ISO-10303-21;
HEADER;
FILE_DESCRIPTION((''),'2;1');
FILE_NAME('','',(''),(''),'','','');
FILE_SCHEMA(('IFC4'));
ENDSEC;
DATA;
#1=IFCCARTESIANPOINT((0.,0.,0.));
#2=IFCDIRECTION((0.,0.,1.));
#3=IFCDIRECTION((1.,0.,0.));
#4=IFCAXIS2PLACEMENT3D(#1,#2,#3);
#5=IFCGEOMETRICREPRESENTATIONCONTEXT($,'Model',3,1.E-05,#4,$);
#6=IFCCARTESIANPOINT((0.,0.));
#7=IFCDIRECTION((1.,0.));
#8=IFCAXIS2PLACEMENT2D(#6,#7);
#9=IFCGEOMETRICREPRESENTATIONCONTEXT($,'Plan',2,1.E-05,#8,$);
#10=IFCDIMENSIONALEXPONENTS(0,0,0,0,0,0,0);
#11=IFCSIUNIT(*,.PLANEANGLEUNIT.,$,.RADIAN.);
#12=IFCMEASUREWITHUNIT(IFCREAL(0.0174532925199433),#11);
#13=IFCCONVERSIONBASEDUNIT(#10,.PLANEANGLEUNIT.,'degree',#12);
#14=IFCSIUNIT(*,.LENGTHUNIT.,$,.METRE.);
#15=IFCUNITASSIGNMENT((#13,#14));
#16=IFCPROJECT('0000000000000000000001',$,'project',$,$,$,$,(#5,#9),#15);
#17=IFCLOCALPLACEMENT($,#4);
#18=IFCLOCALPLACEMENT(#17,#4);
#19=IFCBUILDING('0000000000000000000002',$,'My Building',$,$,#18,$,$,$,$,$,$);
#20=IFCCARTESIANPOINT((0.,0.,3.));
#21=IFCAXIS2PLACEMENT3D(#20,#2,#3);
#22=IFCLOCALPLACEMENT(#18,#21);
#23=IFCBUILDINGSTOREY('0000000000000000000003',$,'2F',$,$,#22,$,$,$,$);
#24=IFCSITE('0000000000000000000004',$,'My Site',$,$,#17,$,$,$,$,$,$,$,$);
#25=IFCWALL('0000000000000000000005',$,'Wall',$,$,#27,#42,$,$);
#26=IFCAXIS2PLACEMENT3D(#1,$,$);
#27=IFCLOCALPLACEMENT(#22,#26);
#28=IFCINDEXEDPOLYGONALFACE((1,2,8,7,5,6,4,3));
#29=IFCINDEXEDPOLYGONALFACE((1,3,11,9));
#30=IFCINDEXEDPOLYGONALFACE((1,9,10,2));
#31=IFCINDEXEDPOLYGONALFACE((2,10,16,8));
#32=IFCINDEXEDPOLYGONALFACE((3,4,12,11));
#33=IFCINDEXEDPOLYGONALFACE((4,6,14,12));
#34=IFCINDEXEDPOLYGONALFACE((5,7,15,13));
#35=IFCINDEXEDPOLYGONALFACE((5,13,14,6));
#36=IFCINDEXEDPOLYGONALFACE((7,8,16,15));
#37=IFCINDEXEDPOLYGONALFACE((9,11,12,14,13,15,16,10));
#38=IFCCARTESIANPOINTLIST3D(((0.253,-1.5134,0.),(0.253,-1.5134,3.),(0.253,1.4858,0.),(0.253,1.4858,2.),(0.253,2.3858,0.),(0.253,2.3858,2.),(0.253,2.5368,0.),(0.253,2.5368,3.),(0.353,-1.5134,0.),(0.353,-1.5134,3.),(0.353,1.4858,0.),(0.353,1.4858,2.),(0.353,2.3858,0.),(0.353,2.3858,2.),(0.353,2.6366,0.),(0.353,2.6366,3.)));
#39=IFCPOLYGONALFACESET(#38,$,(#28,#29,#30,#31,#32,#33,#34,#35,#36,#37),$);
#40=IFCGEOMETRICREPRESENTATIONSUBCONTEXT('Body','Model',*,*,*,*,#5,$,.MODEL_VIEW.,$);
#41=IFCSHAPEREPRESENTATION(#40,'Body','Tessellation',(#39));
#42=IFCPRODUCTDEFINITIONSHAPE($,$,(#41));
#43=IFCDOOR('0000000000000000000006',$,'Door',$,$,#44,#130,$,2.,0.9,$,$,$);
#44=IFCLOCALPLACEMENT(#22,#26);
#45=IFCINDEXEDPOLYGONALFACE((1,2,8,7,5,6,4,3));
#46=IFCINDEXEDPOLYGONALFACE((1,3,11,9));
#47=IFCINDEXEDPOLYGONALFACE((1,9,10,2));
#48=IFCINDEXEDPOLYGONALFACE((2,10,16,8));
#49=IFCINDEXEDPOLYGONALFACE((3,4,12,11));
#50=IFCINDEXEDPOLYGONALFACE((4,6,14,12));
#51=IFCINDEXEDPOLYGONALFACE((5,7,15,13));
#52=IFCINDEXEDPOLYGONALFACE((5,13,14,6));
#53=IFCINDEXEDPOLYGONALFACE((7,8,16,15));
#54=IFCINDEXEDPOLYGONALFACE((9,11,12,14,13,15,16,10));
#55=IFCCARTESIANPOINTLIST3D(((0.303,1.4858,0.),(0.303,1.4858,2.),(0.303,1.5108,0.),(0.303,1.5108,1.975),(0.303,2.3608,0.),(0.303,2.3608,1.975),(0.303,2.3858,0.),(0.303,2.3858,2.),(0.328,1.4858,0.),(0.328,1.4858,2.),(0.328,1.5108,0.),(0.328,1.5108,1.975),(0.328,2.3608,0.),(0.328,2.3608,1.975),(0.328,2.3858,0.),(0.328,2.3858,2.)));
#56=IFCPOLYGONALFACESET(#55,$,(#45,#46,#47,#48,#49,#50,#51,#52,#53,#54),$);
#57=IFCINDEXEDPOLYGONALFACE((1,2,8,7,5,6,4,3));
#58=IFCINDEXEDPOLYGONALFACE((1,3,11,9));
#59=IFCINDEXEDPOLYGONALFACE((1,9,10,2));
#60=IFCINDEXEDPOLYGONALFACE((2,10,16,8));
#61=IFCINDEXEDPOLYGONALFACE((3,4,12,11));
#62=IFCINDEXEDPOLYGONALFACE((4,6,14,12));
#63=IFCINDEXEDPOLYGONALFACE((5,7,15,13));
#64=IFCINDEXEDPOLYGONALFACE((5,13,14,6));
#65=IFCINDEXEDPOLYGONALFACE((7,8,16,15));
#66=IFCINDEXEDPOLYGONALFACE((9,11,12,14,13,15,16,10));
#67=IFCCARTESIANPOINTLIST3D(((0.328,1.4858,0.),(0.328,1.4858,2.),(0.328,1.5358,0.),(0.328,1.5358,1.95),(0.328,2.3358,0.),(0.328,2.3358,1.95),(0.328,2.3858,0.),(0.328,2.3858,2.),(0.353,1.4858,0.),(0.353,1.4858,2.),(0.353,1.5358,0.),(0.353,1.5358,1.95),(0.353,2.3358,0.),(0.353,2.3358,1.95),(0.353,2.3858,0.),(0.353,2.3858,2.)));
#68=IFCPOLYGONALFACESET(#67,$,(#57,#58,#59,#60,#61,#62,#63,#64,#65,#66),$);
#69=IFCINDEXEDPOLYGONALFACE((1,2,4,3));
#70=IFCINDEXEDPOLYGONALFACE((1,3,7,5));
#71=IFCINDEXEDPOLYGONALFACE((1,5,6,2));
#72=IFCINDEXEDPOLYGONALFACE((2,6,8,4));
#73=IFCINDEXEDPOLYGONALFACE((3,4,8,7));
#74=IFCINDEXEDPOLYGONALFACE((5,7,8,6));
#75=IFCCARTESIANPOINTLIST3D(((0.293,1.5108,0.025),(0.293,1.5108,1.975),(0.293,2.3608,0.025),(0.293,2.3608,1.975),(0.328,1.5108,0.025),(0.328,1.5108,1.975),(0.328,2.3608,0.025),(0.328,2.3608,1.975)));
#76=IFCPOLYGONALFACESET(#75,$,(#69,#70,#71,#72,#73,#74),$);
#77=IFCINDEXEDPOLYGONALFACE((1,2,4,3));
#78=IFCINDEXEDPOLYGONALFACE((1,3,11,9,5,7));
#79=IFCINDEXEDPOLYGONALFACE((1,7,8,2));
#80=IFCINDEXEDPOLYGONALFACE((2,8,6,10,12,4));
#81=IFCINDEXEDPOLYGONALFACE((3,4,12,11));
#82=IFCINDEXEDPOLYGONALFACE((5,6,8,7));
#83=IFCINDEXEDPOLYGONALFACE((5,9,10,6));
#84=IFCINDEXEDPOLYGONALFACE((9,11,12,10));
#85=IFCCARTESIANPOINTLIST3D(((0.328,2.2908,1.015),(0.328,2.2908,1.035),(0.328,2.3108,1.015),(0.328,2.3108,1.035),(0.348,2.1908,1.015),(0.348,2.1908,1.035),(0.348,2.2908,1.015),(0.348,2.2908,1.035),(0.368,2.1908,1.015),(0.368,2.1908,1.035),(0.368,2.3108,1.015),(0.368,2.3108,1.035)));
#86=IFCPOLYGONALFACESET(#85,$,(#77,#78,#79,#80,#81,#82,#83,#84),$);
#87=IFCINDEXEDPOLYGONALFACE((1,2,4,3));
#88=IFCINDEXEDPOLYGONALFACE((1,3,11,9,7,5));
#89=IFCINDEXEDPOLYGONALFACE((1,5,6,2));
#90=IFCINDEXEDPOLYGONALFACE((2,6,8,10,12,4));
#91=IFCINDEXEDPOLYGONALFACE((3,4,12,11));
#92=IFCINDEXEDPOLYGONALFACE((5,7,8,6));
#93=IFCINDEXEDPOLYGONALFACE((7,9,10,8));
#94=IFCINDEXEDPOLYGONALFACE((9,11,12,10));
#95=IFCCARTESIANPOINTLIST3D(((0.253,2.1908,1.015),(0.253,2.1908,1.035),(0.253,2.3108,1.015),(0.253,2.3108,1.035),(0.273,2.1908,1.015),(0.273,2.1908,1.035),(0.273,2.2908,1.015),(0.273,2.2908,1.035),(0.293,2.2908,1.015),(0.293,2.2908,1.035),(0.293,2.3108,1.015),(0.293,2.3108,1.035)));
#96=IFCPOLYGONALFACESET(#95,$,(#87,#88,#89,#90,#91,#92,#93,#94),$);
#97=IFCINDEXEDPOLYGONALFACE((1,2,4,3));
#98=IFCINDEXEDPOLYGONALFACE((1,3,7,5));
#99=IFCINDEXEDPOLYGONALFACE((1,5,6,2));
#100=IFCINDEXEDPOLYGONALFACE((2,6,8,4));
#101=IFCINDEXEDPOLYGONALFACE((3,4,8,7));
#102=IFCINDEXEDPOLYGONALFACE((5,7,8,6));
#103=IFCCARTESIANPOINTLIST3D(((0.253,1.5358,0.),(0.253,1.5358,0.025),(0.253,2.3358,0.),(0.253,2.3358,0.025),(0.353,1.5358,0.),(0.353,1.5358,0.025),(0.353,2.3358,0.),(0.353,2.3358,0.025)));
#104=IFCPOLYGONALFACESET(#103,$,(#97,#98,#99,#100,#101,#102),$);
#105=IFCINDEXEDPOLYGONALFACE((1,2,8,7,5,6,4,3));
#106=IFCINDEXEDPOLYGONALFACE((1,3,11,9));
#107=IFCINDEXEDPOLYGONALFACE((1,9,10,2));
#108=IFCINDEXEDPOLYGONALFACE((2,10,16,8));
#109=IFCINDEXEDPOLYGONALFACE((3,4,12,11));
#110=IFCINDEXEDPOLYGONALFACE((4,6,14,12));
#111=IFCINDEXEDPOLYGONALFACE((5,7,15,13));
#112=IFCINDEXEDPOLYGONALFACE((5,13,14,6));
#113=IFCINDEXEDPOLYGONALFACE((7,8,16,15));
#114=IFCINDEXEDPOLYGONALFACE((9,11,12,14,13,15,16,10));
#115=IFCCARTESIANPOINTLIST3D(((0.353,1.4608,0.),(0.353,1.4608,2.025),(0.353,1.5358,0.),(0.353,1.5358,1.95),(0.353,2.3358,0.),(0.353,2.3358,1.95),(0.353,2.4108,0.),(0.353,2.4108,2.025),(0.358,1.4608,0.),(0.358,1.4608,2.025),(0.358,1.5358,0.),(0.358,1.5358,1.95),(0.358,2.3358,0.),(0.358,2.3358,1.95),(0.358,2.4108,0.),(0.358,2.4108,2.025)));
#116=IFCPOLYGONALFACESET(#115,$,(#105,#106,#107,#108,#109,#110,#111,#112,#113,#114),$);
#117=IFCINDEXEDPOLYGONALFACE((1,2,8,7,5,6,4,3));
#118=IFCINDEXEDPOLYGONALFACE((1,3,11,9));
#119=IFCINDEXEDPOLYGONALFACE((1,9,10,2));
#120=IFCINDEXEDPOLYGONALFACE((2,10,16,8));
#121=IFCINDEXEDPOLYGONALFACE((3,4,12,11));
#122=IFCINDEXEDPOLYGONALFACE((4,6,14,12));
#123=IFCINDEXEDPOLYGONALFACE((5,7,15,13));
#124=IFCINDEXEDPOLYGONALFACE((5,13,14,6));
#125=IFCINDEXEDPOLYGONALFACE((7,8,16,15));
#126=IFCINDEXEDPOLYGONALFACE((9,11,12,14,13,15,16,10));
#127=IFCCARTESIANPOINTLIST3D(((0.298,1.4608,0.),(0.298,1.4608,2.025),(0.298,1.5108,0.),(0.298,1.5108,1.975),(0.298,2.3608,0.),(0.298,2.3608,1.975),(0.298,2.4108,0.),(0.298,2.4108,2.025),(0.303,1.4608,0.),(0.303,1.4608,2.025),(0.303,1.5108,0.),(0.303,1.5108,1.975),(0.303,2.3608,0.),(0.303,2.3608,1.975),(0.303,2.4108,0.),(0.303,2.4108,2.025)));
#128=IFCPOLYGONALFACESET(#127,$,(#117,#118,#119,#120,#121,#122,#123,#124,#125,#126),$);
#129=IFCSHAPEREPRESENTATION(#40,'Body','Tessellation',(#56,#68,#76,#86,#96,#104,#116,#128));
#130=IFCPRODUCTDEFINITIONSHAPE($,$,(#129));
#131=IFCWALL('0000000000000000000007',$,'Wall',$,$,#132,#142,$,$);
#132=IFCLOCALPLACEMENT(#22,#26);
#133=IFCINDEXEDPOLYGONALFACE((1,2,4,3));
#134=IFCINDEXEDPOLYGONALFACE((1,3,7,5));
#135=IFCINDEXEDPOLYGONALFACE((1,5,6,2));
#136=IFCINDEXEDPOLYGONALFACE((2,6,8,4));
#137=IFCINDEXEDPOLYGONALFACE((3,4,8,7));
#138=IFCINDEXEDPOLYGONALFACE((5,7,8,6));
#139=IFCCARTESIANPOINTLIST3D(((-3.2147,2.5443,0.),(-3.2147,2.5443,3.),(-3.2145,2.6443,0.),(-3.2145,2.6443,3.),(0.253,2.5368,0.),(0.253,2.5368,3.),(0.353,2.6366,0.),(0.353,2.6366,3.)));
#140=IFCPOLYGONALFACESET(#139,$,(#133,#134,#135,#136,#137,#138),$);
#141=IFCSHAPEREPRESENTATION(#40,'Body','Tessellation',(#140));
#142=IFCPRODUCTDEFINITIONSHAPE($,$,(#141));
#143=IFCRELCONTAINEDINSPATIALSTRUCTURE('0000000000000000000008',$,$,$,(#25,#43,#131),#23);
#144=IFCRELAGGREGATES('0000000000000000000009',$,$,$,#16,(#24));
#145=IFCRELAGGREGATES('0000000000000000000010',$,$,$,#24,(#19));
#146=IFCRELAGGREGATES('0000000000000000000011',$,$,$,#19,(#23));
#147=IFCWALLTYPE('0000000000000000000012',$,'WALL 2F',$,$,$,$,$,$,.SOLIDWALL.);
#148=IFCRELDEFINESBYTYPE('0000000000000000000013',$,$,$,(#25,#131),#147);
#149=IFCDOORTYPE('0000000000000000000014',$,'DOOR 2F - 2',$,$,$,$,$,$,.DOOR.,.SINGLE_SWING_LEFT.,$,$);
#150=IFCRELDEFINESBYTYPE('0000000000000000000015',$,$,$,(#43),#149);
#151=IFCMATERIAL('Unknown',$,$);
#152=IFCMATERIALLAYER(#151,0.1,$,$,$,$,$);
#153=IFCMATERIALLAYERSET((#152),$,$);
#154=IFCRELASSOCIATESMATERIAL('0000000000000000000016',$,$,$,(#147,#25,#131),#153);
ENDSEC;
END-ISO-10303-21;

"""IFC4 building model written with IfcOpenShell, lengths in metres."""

from ifc_helpers import new_model, entity, si_unit, converted_unit, frame, origin_with_axes, origin_2d_with_axis, place, context, subcontext, project, spatial, line, indexed_curve, outline, extrude, shape, source, transform, mapped, material, layer, layer_set, layer_usage, type_object, type_shapes, element, fill, save


model = new_model("IFC4")

# Units and contexts
model_context = context("Model", 3, precision=1e-05, world=origin_with_axes())
plan_context = context("Plan", 2, precision=1e-05, world=origin_2d_with_axis())
body_context_1 = subcontext(model_context, "Body", "Model", "MODEL_VIEW")
body_context_2 = subcontext(plan_context, "Body", "Plan", "PLAN_VIEW")
ifc_project = project(units=[converted_unit("PLANEANGLEUNIT", "degree", entity("IfcReal", 0.0174532925199433), si_unit("PLANEANGLEUNIT", "RADIAN"), dimensions=[0, 0, 0, 0, 0, 0, 0]), si_unit("LENGTHUNIT", "METRE")], contexts=[model_context, plan_context])

# Site, building, storey
site_placement = place(None, origin_with_axes())
site = spatial("IfcSite", under=ifc_project, at=site_placement, Name="My Site")
building_placement = place(site_placement, origin_with_axes())
building = spatial("IfcBuilding", under=site, at=building_placement, Name="My Building")
storey_placement = place(building_placement, frame((0.0, 0.0, 3.0), z_axis=(0.0, 0.0, 1.0), x_axis=(1.0, 0.0, 0.0)))
storey = spatial("IfcBuildingStorey", under=building, at=storey_placement, Name="2F")

# Shared definitions
ifc_material = material(Name="Unknown")

# Shared definitions
ifc_layer_1 = layer(ifc_material, 0.1)
ifc_layer_set_1 = layer_set([ifc_layer_1])
wall_type = type_object("IfcWallType", Name="WALL 2F", PredefinedType="SOLIDWALL", material=ifc_layer_set_1)

# Wall, opening, door
ifc_layer_usage_1 = layer_usage(ifc_layer_set_1, "AXIS2", "POSITIVE", 0.0)
wall_1_placement = place(storey_placement, frame((0.353, -1.5134, 0.0), z_axis=(0.0, 0.0, 1.0), x_axis=(0.0, 1.0, 0.0)))
wall_1 = element("IfcWall", 1, at=wall_1_placement, inside=storey, type_object=wall_type, material=ifc_layer_usage_1, Name="Wall", context=body_context_1, shape_type="SweptSolid", body=[
    extrude(outline(indexed_curve([(0.0, 0.0), (0.0, 0.1), (4.0502, 0.1), (4.15, 0.0)], segments=[line(1, 2, 3, 4, 1)])), origin_with_axes(), (0.0, 0.0, 1.0), 3.0),
])
shared_shape_1 = source(origin_with_axes(), body_context_1, "Body", "SweptSolid", [
    extrude(outline(indexed_curve([(0.0, 0.0), (0.9, 0.0), (0.9, 2.0), (0.0, 2.0)], segments=[line(1, 2, 3, 4, 1)])), frame((0.0, -0.6, 0.0), z_axis=(0.0, -1.0, 0.0), x_axis=(1.0, 0.0, 0.0)), (0.0, 0.0, -1.0), 1.2),
])
opening_1_placement = place(wall_1_placement, frame((2.9992, 0.0, 0.0), z_axis=(0.0, 0.0, 1.0), x_axis=(1.0, 0.0, 0.0)))
opening_1 = element("IfcOpeningElement", 2, at=opening_1_placement, cuts=wall_1, PredefinedType="OPENING", context=body_context_1, shape_type="MappedRepresentation", body=[
    mapped(shared_shape_1, transform((0.0, 0.0, 0.0), x_axis=(1.0, 0.0, 0.0), y_axis=(0.0, 1.0, 0.0), z_axis=(0.0, 0.0, 1.0), scale=1.0)),
])
door_type_1 = type_object("IfcDoorType", Name="DOOR 2F - 2", OperationType="SINGLE_SWING_LEFT", PredefinedType="DOOR")
shared_shape_2 = source(origin_with_axes(), body_context_1, "Body", "SweptSolid", [
    extrude(outline(indexed_curve([(0.0, 0.0), (0.0, 2.0), (0.9, 2.0), (0.9, 0.0), (0.875, 0.0), (0.875, 1.975), (0.025, 1.975), (0.025, 0.0)], segments=[line(1, 2, 3, 4, 5, 6, 7, 8, 1)])), frame((0.0, 0.025, 0.0), z_axis=(0.0, -1.0, 0.0), x_axis=(1.0, 0.0, 0.0)), (0.0, 0.0, -1.0), 0.025),
    extrude(outline(indexed_curve([(0.0, 0.0), (0.0, 2.0), (0.9, 2.0), (0.9, 0.0), (0.85, 0.0), (0.85, 1.95), (0.05, 1.95), (0.05, 0.0)], segments=[line(1, 2, 3, 4, 5, 6, 7, 8, 1)])), frame((0.0, 0.0, 0.0), z_axis=(0.0, -1.0, 0.0), x_axis=(1.0, 0.0, 0.0)), (0.0, 0.0, -1.0), 0.025),
    extrude(outline(indexed_curve([(0.0, 0.0), (0.85, 0.0), (0.85, 0.035), (0.0, 0.035)], segments=[line(1, 2, 3, 4, 1)])), frame((0.025, 0.025, 0.025), z_axis=(0.0, 0.0, 1.0), x_axis=(1.0, 0.0, 0.0)), (0.0, 0.0, 1.0), 1.95),
    extrude(outline(indexed_curve([(0.0, 0.0), (0.0, -0.04), (-0.12, -0.04), (-0.12, -0.02), (-0.02, -0.02), (-0.02, 0.0)], segments=[line(1, 2, 3, 4, 5, 6, 1)])), frame((0.825, 0.025, 1.015), z_axis=(0.0, 0.0, 1.0), x_axis=(1.0, 0.0, 0.0)), (0.0, 0.0, 1.0), 0.02),
    extrude(outline(indexed_curve([(0.0, 0.0), (0.0, 0.04), (-0.12, 0.04), (-0.12, 0.02), (-0.02, 0.02), (-0.02, 0.0)], segments=[line(1, 2, 3, 4, 5, 6, 1)])), frame((0.825, 0.06, 1.015), z_axis=(0.0, 0.0, 1.0), x_axis=(1.0, 0.0, 0.0)), (0.0, 0.0, 1.0), 0.02),
    extrude(outline(indexed_curve([(0.0, 0.0), (0.8, 0.0), (0.8, 0.1), (0.0, 0.1)], segments=[line(1, 2, 3, 4, 1)])), frame((0.05, 0.0, 0.0), z_axis=(0.0, 0.0, 1.0), x_axis=(1.0, 0.0, 0.0)), (0.0, 0.0, 1.0), 0.025),
    extrude(outline(indexed_curve([(0.0, 0.0), (0.0, 2.025), (0.95, 2.025), (0.95, 0.0), (0.875, 0.0), (0.875, 1.95), (0.075, 1.95), (0.075, 0.0)], segments=[line(1, 2, 3, 4, 5, 6, 7, 8, 1)])), frame((-0.025, -0.005, 0.0), z_axis=(0.0, -1.0, 0.0), x_axis=(1.0, 0.0, 0.0)), (0.0, 0.0, -1.0), 0.005),
    extrude(outline(indexed_curve([(0.0, 0.0), (0.0, 2.025), (0.95, 2.025), (0.95, 0.0), (0.9, 0.0), (0.9, 1.975), (0.05, 1.975), (0.05, 0.0)], segments=[line(1, 2, 3, 4, 5, 6, 7, 8, 1)])), frame((-0.025, 0.05, 0.0), z_axis=(0.0, -1.0, 0.0), x_axis=(1.0, 0.0, 0.0)), (0.0, 0.0, -1.0), 0.005),
])
shared_shape_3 = source(origin_with_axes(), body_context_2, "Body", "Curve2D", [
    entity("IfcIndexedPolyCurve", entity("IfcCartesianPointList2D", [[0.0, 0.0], [0.0, 0.05], [0.025, 0.05], [0.025, 0.025], [0.05, 0.025], [0.05, 0.0]]), [entity("IfcLineIndex", [1, 2, 3, 4, 5, 6, 1])]),
    entity("IfcIndexedPolyCurve", entity("IfcCartesianPointList2D", [[0.9, 0.0], [0.9, 0.05], [0.875, 0.05], [0.875, 0.025], [0.85, 0.025], [0.85, 0.0]]), [entity("IfcLineIndex", [1, 2, 3, 4, 5, 6, 1])]),
    entity("IfcTrimmedCurve", entity("IfcEllipse", entity("IfcAxis2Placement2D", entity("IfcCartesianPoint", [0.06, 0.05]), entity("IfcDirection", [1.0, 0.0])), 0.815, 0.85), [entity("IfcCartesianPoint", [0.875, 0.05])], [entity("IfcCartesianPoint", [0.06, 0.9])], True, "CARTESIAN"),
    entity("IfcIndexedPolyCurve", entity("IfcCartesianPointList2D", [[0.025, 0.05], [0.06, 0.05], [0.06, 0.9], [0.025, 0.9]]), [entity("IfcLineIndex", [1, 2, 3, 4, 1])]),
])
type_shapes(door_type_1, [shared_shape_2, shared_shape_3])
door_1_placement = place(opening_1_placement, frame((0.0, 0.0, 0.0), z_axis=(0.0, 0.0, 1.0), x_axis=(1.0, 0.0, 0.0)))
door_1 = element("IfcDoor", 3, at=door_1_placement, inside=storey, type_object=door_type_1, Name="Door", OverallHeight=2.0, OverallWidth=0.9, shapes=[
    shape(body_context_1, "Body", "MappedRepresentation", [mapped(shared_shape_2, transform((0.0, 0.0, 0.0), x_axis=(1.0, 0.0, 0.0), y_axis=(0.0, 1.0, 0.0), z_axis=(0.0, 0.0, 1.0), scale=1.0))]),
    shape(body_context_2, "Body", "MappedRepresentation", [mapped(shared_shape_3, transform((0.0, 0.0, 0.0), x_axis=(1.0, 0.0, 0.0), y_axis=(0.0, 1.0, 0.0), z_axis=(0.0, 0.0, 1.0), scale=1.0))]),
])
fill(opening_1, door_1)

# Wall
ifc_layer_usage_2 = layer_usage(ifc_layer_set_1, "AXIS2", "POSITIVE", 0.0)
wall_2_placement = place(storey_placement, frame((0.353, 2.6366, 0.0), z_axis=(0.0, 0.0, 1.0), x_axis=(-0.999998, 0.002185, 0.0)))
element("IfcWall", 4, at=wall_2_placement, inside=storey, type_object=wall_type, material=ifc_layer_usage_2, Name="Wall", context=body_context_1, shape_type="SweptSolid", body=[
    extrude(outline(indexed_curve([(0.0, 0.0), (0.0998, 0.1), (3.5675, 0.1), (3.5675, 0.0)], segments=[line(1, 2, 3, 4, 1)])), origin_with_axes(), (0.0, 0.0, 1.0), 3.0),
])

save(model, "model.ifc")
